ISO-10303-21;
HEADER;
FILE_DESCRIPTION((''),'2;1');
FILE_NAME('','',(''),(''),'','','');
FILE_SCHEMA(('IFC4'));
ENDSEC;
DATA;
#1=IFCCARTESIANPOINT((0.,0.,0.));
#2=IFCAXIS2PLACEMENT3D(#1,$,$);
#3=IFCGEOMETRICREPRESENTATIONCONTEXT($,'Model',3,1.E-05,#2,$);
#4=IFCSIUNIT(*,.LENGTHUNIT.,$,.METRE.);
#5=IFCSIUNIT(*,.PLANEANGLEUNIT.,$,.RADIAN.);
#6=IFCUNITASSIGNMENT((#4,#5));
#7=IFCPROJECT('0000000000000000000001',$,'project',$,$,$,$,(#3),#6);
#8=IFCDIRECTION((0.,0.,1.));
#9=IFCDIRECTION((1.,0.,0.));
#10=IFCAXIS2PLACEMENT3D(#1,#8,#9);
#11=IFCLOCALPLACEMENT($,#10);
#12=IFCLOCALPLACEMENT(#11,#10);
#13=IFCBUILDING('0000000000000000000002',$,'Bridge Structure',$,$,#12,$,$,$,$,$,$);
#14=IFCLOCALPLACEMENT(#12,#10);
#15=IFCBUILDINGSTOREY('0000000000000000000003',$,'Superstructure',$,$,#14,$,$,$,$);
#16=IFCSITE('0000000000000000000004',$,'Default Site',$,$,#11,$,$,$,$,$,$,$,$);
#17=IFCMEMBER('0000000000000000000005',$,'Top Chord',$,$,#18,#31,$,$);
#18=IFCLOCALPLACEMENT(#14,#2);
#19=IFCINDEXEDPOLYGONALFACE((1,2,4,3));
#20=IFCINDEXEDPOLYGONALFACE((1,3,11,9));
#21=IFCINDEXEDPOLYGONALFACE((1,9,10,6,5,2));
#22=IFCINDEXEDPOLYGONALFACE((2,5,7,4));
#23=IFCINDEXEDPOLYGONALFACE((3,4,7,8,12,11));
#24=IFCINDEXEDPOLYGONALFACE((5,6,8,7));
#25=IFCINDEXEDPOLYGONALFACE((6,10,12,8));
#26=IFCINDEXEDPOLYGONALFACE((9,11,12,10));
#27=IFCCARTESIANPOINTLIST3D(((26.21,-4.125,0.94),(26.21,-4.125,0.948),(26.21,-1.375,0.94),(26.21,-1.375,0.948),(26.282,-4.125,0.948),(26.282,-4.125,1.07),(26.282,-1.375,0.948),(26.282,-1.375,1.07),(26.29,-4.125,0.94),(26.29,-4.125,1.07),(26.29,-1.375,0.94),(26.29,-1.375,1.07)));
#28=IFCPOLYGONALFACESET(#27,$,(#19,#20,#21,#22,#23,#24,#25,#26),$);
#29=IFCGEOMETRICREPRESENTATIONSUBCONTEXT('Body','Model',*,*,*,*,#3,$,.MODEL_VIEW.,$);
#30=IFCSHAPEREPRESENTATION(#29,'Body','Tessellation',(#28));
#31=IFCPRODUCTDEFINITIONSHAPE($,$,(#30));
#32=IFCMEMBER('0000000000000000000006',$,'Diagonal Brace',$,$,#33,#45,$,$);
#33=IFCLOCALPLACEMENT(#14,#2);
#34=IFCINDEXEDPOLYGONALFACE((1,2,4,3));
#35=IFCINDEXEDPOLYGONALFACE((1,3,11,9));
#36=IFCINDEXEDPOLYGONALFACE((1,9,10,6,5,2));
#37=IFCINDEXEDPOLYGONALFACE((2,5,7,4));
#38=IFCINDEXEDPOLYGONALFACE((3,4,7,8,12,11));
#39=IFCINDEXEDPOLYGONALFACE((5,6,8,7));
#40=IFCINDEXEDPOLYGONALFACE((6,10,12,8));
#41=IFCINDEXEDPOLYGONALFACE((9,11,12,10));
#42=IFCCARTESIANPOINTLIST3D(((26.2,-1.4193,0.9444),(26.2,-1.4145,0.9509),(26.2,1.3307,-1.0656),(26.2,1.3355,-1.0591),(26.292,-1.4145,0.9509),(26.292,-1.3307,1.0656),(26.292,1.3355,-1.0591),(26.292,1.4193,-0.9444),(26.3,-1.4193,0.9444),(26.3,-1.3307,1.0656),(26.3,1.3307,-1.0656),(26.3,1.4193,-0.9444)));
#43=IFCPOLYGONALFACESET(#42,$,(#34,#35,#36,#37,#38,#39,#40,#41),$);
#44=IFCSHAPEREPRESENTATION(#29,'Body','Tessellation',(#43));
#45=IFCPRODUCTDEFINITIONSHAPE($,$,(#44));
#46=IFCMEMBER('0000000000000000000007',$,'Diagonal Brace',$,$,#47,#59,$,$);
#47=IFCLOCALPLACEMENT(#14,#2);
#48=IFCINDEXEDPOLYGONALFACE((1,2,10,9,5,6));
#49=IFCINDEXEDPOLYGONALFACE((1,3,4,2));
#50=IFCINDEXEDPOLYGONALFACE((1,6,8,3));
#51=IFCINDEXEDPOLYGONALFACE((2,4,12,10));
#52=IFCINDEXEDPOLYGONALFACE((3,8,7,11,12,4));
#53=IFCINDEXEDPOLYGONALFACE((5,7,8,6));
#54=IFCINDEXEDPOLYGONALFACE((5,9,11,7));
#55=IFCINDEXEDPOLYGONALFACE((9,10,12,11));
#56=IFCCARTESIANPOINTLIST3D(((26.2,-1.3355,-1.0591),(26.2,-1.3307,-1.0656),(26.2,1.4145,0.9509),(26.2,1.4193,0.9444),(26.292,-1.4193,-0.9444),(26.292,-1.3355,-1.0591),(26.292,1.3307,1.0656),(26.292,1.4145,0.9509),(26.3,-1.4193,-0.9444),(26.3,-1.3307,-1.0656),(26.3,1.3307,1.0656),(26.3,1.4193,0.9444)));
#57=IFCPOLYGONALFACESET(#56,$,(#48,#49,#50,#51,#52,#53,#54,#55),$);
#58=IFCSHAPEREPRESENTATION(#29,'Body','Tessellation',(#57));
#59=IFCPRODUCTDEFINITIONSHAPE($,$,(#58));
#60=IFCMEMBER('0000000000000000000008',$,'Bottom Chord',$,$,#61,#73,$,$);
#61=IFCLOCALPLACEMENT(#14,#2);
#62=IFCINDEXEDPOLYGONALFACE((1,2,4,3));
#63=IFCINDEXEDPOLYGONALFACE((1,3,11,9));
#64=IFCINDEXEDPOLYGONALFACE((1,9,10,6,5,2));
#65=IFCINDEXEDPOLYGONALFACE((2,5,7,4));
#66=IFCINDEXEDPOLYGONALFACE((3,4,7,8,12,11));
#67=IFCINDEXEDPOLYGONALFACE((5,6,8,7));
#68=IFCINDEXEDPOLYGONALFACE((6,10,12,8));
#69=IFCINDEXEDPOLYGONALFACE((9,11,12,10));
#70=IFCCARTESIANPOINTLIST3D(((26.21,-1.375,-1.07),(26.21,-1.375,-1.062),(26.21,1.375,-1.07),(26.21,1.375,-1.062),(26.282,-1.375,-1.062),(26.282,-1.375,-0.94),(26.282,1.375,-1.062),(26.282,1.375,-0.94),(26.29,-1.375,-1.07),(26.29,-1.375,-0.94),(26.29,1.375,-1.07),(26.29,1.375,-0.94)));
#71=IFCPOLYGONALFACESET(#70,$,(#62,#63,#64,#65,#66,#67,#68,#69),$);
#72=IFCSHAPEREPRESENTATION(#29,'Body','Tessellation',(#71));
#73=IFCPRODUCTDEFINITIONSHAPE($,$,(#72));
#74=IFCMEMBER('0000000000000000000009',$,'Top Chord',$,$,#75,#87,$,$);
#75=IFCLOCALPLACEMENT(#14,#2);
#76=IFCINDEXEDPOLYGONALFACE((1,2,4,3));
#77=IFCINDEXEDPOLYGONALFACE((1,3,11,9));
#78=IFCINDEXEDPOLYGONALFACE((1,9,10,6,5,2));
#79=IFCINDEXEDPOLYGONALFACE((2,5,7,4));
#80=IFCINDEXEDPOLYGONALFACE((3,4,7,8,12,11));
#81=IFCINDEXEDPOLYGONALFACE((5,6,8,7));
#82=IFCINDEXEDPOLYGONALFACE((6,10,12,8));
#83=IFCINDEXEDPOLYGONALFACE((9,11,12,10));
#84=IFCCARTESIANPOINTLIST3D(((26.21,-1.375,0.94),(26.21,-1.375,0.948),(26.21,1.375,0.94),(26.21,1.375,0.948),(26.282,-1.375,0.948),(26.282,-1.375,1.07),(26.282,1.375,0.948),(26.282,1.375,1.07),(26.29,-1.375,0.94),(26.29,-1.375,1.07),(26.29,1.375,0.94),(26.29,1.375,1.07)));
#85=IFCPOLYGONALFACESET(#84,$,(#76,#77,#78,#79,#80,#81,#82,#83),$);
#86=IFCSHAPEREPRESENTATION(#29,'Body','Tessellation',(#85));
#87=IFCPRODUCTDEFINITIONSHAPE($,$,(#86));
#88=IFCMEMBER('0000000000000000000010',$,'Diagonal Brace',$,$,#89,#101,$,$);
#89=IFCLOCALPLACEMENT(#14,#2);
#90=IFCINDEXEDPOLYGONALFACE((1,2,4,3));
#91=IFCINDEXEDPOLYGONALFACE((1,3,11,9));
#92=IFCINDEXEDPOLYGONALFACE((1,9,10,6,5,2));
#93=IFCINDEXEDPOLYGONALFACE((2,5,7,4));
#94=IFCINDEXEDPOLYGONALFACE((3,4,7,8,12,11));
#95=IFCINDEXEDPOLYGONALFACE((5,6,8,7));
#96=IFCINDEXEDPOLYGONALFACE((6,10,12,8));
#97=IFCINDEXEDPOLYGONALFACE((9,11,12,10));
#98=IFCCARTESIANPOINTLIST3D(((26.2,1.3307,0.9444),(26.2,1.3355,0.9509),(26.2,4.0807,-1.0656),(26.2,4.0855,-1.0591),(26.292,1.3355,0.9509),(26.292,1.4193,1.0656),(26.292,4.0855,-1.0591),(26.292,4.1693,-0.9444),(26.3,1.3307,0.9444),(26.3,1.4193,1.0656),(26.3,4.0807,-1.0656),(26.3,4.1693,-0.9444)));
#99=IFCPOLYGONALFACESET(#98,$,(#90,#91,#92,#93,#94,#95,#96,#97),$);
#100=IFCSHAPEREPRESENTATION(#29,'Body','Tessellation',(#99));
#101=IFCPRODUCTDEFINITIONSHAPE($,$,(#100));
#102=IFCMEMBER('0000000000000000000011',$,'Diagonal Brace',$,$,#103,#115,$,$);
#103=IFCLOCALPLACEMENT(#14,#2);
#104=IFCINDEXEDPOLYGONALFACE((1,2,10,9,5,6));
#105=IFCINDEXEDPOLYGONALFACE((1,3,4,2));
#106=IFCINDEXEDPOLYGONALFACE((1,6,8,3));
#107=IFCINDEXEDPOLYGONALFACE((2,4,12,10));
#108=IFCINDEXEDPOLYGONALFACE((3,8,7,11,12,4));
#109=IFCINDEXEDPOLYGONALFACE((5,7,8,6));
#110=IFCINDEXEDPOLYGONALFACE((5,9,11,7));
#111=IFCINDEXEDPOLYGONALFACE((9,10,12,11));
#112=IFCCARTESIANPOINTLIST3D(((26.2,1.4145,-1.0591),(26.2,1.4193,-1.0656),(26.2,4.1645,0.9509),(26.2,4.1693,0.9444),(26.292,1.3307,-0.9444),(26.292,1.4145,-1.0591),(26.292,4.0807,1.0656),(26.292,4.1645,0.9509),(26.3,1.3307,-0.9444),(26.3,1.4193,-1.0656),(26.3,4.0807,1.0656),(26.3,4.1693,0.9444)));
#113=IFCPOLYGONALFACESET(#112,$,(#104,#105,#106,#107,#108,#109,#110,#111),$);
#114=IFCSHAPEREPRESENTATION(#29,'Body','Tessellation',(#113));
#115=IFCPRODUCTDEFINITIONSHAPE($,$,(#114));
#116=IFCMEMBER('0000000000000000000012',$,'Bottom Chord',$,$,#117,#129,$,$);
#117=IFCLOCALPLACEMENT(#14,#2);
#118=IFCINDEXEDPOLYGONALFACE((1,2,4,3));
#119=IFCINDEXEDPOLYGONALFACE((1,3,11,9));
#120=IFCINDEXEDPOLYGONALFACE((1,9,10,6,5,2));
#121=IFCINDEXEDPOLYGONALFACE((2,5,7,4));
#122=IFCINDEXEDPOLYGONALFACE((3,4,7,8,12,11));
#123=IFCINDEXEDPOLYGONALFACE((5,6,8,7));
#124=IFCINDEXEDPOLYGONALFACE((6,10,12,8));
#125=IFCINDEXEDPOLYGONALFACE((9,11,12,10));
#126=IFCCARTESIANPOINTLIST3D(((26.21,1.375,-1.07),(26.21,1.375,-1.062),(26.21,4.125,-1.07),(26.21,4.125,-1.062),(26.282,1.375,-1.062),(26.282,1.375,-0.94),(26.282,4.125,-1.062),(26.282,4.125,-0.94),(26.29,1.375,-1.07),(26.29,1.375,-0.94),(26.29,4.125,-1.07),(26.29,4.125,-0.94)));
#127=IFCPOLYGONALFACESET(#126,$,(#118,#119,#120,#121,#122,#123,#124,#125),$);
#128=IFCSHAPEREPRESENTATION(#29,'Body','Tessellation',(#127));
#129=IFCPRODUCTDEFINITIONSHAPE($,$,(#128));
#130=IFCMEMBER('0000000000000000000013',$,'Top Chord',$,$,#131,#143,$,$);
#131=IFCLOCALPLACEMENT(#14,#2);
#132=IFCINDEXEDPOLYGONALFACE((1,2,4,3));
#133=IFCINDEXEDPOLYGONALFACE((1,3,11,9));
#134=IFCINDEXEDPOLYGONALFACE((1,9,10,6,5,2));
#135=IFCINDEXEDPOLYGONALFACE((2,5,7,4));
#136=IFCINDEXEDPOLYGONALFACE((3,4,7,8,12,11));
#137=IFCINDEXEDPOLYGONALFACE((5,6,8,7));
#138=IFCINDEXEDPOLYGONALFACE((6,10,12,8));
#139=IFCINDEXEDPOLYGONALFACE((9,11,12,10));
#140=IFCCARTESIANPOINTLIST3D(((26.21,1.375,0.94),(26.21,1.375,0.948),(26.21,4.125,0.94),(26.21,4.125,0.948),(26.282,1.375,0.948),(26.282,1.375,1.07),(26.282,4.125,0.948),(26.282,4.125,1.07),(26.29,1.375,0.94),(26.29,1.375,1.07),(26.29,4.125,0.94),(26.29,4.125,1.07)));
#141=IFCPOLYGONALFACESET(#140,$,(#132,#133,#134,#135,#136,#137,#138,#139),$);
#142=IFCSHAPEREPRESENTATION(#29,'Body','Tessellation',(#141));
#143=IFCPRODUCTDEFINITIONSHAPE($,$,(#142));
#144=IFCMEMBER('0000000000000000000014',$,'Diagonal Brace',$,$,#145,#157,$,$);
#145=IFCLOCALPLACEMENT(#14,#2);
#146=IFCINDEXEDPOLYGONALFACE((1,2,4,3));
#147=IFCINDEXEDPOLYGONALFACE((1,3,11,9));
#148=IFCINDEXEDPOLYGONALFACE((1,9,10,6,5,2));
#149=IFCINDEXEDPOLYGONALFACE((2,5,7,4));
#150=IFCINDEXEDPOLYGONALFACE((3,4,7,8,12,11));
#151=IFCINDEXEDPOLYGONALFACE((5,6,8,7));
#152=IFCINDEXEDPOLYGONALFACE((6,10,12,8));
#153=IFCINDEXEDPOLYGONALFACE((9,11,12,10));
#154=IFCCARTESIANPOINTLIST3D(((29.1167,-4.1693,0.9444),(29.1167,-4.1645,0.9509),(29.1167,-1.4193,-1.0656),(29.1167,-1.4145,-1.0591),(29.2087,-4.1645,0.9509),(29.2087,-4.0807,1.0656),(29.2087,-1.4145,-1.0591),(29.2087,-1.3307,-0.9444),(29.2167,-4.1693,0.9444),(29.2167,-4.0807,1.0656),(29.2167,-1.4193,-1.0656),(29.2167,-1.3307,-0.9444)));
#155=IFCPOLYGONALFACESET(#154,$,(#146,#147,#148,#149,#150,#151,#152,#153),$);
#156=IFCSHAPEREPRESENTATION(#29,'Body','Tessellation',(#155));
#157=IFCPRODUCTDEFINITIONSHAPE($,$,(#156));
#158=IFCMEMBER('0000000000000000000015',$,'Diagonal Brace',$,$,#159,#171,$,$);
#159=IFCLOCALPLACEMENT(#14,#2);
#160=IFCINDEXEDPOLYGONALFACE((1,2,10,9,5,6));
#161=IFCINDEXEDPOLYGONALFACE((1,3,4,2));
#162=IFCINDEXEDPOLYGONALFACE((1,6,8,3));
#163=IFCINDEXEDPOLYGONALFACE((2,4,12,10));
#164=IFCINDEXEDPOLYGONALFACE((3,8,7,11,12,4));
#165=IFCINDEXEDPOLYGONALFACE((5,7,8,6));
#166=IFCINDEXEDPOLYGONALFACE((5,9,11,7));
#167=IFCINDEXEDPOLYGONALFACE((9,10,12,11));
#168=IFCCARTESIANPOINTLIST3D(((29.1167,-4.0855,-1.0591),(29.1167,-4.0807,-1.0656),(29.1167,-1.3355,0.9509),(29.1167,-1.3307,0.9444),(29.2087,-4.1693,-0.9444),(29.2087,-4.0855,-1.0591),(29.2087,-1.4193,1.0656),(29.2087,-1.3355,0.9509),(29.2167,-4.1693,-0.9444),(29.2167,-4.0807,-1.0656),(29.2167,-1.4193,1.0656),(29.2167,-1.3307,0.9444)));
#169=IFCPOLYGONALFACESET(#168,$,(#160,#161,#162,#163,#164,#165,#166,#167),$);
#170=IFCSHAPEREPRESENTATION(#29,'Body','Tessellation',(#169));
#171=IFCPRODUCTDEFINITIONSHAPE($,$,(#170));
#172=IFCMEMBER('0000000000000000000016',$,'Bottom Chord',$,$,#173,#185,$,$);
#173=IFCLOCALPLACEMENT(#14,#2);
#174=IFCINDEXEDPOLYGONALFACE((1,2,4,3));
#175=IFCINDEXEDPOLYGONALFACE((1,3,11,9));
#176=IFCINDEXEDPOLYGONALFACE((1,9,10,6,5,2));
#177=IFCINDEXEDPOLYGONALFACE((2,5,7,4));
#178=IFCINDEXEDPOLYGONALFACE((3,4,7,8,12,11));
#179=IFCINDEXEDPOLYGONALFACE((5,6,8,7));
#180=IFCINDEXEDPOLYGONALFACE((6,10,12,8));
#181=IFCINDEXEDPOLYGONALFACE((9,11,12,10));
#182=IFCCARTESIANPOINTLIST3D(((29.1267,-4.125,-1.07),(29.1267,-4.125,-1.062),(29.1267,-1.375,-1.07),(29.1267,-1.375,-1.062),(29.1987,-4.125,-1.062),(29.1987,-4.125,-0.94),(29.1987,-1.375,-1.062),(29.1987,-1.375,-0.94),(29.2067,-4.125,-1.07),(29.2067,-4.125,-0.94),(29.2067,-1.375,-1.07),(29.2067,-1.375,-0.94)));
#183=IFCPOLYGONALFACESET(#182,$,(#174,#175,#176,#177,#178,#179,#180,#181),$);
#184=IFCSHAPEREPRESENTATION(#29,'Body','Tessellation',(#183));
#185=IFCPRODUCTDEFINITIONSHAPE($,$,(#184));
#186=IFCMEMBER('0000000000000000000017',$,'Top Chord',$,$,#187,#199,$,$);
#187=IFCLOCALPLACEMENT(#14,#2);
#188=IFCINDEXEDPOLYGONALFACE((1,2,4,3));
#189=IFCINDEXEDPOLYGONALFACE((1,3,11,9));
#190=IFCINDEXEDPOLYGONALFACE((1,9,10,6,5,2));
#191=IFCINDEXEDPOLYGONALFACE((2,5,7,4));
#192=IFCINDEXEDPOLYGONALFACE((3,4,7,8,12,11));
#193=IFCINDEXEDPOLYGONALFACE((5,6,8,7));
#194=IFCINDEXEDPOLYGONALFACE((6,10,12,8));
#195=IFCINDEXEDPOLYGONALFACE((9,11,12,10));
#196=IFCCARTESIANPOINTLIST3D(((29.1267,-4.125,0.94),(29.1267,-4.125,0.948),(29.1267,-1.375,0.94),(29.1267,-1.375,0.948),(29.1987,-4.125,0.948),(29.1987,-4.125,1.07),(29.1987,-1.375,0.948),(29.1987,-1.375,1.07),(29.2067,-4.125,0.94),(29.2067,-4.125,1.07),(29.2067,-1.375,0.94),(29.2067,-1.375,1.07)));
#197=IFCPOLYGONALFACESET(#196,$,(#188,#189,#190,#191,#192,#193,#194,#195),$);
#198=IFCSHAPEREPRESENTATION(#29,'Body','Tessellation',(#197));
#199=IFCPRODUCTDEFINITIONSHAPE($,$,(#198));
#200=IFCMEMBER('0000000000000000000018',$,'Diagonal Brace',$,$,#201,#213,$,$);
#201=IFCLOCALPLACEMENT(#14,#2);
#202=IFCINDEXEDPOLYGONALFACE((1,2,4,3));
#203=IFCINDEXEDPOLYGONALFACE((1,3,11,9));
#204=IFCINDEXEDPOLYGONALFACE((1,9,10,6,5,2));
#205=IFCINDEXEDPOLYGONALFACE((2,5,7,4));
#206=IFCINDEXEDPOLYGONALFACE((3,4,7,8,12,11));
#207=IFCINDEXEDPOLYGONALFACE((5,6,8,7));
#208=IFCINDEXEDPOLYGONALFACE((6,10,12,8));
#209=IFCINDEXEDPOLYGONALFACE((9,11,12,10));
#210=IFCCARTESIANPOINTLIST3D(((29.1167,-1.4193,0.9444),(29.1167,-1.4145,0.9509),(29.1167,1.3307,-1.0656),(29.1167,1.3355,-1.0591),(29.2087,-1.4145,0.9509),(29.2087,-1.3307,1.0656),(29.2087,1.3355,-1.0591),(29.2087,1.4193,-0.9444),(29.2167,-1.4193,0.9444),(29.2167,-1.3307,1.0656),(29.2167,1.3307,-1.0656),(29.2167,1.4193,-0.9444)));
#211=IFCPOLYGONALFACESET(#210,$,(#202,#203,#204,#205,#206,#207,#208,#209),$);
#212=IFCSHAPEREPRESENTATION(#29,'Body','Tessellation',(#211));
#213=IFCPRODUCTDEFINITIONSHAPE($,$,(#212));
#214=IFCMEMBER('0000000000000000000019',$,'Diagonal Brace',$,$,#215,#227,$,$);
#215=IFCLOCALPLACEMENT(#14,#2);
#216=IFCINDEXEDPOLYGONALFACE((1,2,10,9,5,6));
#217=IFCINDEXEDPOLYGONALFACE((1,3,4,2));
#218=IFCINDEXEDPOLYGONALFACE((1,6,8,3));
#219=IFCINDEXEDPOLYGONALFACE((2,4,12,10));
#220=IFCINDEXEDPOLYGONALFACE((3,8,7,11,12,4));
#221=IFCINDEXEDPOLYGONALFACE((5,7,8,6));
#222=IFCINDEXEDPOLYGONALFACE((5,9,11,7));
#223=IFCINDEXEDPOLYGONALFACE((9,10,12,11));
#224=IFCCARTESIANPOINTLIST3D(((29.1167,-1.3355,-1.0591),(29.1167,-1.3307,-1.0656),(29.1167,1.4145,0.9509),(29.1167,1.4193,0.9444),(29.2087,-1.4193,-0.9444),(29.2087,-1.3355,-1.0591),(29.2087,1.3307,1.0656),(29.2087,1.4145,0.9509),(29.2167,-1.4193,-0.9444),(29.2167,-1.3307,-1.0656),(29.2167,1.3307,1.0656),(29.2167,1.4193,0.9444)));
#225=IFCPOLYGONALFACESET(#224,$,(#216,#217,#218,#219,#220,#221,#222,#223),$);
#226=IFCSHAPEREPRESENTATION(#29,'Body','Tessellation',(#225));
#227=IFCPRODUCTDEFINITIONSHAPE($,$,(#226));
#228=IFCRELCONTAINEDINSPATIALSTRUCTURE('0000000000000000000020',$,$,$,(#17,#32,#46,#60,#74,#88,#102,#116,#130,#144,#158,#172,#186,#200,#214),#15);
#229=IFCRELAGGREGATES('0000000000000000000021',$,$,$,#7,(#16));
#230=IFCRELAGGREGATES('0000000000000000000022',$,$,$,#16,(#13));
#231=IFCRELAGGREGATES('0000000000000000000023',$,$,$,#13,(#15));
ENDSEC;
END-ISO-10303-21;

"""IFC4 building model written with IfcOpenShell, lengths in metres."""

from ifc_helpers import new_model, si_unit, frame, origin, origin_with_axes, origin_2d_with_axis, place, context, subcontext, project, spatial, l_section, extrude, element, save


model = new_model("IFC4")

# Units and contexts
model_context = context("Model", 3, precision=1e-05, world=origin())
body_context = subcontext(model_context, "Body", "Model", "MODEL_VIEW")
ifc_project = project(units=[si_unit("LENGTHUNIT", "METRE"), si_unit("PLANEANGLEUNIT", "RADIAN")], contexts=[model_context])

# Site, building, storey
site_placement = place(None, origin_with_axes())
site = spatial("IfcSite", under=ifc_project, at=site_placement, Name="Default Site")
building_placement = place(site_placement, origin_with_axes())
building = spatial("IfcBuilding", under=site, at=building_placement, Name="Bridge Structure")
storey_placement = place(building_placement, origin_with_axes())
storey = spatial("IfcBuildingStorey", under=building, at=storey_placement, Name="Superstructure")

# Members
member_placement = place(storey_placement, frame((26.25, -4.125, 1.005), z_axis=(0.0, 1.0, 0.0), x_axis=(-1.0, 0.0, 0.0)))
element("IfcMember", 1, at=member_placement, inside=storey, Name="Top Chord", context=body_context, shape_type="SweptSolid", body=[
    extrude(l_section(Depth=0.13, Width=0.08, Thickness=0.008, at=origin_2d_with_axis()), origin_with_axes(), (0.0, 0.0, 1.0), 2.75),
])
for number, where, z_axis, x_axis, name in (
    (2, (26.25, -1.375, 1.005), (0.0, 0.807337, -0.59009), (-1.0, 0.0, 0.0), "Diagonal Brace"),
    (3, (26.25, -1.375, -1.005), (0.0, 0.807337, 0.59009), (-1.0, 0.0, 0.0), "Diagonal Brace"),
):
    element("IfcMember", number, at=place(storey_placement, frame(where, z_axis=z_axis, x_axis=x_axis)), inside=storey, Name=name, context=body_context, shape_type="SweptSolid", body=[
        extrude(l_section(Depth=0.15, Width=0.1, Thickness=0.008, at=origin_2d_with_axis()), origin_with_axes(), (0.0, 0.0, 1.0), 3.4063),
    ])
for number, where, z_axis, x_axis, name in (
    (4, (26.25, -1.375, -1.005), (0.0, 1.0, 0.0), (-1.0, 0.0, 0.0), "Bottom Chord"),
    (5, (26.25, -1.375, 1.005), (0.0, 1.0, 0.0), (-1.0, 0.0, 0.0), "Top Chord"),
):
    element("IfcMember", number, at=place(storey_placement, frame(where, z_axis=z_axis, x_axis=x_axis)), inside=storey, Name=name, context=body_context, shape_type="SweptSolid", body=[
        extrude(l_section(Depth=0.13, Width=0.08, Thickness=0.008, at=origin_2d_with_axis()), origin_with_axes(), (0.0, 0.0, 1.0), 2.75),
    ])
for number, where, z_axis, x_axis, name in (
    (6, (26.25, 1.375, 1.005), (0.0, 0.807337, -0.59009), (-1.0, 0.0, 0.0), "Diagonal Brace"),
    (7, (26.25, 1.375, -1.005), (0.0, 0.807337, 0.59009), (-1.0, 0.0, 0.0), "Diagonal Brace"),
):
    element("IfcMember", number, at=place(storey_placement, frame(where, z_axis=z_axis, x_axis=x_axis)), inside=storey, Name=name, context=body_context, shape_type="SweptSolid", body=[
        extrude(l_section(Depth=0.15, Width=0.1, Thickness=0.008, at=origin_2d_with_axis()), origin_with_axes(), (0.0, 0.0, 1.0), 3.4063),
    ])
for number, where, z_axis, x_axis, name in (
    (8, (26.25, 1.375, -1.005), (0.0, 1.0, 0.0), (-1.0, 0.0, 0.0), "Bottom Chord"),
    (9, (26.25, 1.375, 1.005), (0.0, 1.0, 0.0), (-1.0, 0.0, 0.0), "Top Chord"),
):
    element("IfcMember", number, at=place(storey_placement, frame(where, z_axis=z_axis, x_axis=x_axis)), inside=storey, Name=name, context=body_context, shape_type="SweptSolid", body=[
        extrude(l_section(Depth=0.13, Width=0.08, Thickness=0.008, at=origin_2d_with_axis()), origin_with_axes(), (0.0, 0.0, 1.0), 2.75),
    ])
for number, where, z_axis, x_axis, name in (
    (10, (29.1667, -4.125, 1.005), (0.0, 0.807337, -0.59009), (-1.0, 0.0, 0.0), "Diagonal Brace"),
    (11, (29.1667, -4.125, -1.005), (0.0, 0.807337, 0.59009), (-1.0, 0.0, 0.0), "Diagonal Brace"),
):
    element("IfcMember", number, at=place(storey_placement, frame(where, z_axis=z_axis, x_axis=x_axis)), inside=storey, Name=name, context=body_context, shape_type="SweptSolid", body=[
        extrude(l_section(Depth=0.15, Width=0.1, Thickness=0.008, at=origin_2d_with_axis()), origin_with_axes(), (0.0, 0.0, 1.0), 3.4063),
    ])
for number, where, z_axis, x_axis, name in (
    (12, (29.1667, -4.125, -1.005), (0.0, 1.0, 0.0), (-1.0, 0.0, 0.0), "Bottom Chord"),
    (13, (29.1667, -4.125, 1.005), (0.0, 1.0, 0.0), (-1.0, 0.0, 0.0), "Top Chord"),
):
    element("IfcMember", number, at=place(storey_placement, frame(where, z_axis=z_axis, x_axis=x_axis)), inside=storey, Name=name, context=body_context, shape_type="SweptSolid", body=[
        extrude(l_section(Depth=0.13, Width=0.08, Thickness=0.008, at=origin_2d_with_axis()), origin_with_axes(), (0.0, 0.0, 1.0), 2.75),
    ])
for number, where, z_axis, x_axis, name in (
    (14, (29.1667, -1.375, 1.005), (0.0, 0.807337, -0.59009), (-1.0, 0.0, 0.0), "Diagonal Brace"),
    (15, (29.1667, -1.375, -1.005), (0.0, 0.807337, 0.59009), (-1.0, 0.0, 0.0), "Diagonal Brace"),
):
    element("IfcMember", number, at=place(storey_placement, frame(where, z_axis=z_axis, x_axis=x_axis)), inside=storey, Name=name, context=body_context, shape_type="SweptSolid", body=[
        extrude(l_section(Depth=0.15, Width=0.1, Thickness=0.008, at=origin_2d_with_axis()), origin_with_axes(), (0.0, 0.0, 1.0), 3.4063),
    ])

save(model, "model.ifc")
